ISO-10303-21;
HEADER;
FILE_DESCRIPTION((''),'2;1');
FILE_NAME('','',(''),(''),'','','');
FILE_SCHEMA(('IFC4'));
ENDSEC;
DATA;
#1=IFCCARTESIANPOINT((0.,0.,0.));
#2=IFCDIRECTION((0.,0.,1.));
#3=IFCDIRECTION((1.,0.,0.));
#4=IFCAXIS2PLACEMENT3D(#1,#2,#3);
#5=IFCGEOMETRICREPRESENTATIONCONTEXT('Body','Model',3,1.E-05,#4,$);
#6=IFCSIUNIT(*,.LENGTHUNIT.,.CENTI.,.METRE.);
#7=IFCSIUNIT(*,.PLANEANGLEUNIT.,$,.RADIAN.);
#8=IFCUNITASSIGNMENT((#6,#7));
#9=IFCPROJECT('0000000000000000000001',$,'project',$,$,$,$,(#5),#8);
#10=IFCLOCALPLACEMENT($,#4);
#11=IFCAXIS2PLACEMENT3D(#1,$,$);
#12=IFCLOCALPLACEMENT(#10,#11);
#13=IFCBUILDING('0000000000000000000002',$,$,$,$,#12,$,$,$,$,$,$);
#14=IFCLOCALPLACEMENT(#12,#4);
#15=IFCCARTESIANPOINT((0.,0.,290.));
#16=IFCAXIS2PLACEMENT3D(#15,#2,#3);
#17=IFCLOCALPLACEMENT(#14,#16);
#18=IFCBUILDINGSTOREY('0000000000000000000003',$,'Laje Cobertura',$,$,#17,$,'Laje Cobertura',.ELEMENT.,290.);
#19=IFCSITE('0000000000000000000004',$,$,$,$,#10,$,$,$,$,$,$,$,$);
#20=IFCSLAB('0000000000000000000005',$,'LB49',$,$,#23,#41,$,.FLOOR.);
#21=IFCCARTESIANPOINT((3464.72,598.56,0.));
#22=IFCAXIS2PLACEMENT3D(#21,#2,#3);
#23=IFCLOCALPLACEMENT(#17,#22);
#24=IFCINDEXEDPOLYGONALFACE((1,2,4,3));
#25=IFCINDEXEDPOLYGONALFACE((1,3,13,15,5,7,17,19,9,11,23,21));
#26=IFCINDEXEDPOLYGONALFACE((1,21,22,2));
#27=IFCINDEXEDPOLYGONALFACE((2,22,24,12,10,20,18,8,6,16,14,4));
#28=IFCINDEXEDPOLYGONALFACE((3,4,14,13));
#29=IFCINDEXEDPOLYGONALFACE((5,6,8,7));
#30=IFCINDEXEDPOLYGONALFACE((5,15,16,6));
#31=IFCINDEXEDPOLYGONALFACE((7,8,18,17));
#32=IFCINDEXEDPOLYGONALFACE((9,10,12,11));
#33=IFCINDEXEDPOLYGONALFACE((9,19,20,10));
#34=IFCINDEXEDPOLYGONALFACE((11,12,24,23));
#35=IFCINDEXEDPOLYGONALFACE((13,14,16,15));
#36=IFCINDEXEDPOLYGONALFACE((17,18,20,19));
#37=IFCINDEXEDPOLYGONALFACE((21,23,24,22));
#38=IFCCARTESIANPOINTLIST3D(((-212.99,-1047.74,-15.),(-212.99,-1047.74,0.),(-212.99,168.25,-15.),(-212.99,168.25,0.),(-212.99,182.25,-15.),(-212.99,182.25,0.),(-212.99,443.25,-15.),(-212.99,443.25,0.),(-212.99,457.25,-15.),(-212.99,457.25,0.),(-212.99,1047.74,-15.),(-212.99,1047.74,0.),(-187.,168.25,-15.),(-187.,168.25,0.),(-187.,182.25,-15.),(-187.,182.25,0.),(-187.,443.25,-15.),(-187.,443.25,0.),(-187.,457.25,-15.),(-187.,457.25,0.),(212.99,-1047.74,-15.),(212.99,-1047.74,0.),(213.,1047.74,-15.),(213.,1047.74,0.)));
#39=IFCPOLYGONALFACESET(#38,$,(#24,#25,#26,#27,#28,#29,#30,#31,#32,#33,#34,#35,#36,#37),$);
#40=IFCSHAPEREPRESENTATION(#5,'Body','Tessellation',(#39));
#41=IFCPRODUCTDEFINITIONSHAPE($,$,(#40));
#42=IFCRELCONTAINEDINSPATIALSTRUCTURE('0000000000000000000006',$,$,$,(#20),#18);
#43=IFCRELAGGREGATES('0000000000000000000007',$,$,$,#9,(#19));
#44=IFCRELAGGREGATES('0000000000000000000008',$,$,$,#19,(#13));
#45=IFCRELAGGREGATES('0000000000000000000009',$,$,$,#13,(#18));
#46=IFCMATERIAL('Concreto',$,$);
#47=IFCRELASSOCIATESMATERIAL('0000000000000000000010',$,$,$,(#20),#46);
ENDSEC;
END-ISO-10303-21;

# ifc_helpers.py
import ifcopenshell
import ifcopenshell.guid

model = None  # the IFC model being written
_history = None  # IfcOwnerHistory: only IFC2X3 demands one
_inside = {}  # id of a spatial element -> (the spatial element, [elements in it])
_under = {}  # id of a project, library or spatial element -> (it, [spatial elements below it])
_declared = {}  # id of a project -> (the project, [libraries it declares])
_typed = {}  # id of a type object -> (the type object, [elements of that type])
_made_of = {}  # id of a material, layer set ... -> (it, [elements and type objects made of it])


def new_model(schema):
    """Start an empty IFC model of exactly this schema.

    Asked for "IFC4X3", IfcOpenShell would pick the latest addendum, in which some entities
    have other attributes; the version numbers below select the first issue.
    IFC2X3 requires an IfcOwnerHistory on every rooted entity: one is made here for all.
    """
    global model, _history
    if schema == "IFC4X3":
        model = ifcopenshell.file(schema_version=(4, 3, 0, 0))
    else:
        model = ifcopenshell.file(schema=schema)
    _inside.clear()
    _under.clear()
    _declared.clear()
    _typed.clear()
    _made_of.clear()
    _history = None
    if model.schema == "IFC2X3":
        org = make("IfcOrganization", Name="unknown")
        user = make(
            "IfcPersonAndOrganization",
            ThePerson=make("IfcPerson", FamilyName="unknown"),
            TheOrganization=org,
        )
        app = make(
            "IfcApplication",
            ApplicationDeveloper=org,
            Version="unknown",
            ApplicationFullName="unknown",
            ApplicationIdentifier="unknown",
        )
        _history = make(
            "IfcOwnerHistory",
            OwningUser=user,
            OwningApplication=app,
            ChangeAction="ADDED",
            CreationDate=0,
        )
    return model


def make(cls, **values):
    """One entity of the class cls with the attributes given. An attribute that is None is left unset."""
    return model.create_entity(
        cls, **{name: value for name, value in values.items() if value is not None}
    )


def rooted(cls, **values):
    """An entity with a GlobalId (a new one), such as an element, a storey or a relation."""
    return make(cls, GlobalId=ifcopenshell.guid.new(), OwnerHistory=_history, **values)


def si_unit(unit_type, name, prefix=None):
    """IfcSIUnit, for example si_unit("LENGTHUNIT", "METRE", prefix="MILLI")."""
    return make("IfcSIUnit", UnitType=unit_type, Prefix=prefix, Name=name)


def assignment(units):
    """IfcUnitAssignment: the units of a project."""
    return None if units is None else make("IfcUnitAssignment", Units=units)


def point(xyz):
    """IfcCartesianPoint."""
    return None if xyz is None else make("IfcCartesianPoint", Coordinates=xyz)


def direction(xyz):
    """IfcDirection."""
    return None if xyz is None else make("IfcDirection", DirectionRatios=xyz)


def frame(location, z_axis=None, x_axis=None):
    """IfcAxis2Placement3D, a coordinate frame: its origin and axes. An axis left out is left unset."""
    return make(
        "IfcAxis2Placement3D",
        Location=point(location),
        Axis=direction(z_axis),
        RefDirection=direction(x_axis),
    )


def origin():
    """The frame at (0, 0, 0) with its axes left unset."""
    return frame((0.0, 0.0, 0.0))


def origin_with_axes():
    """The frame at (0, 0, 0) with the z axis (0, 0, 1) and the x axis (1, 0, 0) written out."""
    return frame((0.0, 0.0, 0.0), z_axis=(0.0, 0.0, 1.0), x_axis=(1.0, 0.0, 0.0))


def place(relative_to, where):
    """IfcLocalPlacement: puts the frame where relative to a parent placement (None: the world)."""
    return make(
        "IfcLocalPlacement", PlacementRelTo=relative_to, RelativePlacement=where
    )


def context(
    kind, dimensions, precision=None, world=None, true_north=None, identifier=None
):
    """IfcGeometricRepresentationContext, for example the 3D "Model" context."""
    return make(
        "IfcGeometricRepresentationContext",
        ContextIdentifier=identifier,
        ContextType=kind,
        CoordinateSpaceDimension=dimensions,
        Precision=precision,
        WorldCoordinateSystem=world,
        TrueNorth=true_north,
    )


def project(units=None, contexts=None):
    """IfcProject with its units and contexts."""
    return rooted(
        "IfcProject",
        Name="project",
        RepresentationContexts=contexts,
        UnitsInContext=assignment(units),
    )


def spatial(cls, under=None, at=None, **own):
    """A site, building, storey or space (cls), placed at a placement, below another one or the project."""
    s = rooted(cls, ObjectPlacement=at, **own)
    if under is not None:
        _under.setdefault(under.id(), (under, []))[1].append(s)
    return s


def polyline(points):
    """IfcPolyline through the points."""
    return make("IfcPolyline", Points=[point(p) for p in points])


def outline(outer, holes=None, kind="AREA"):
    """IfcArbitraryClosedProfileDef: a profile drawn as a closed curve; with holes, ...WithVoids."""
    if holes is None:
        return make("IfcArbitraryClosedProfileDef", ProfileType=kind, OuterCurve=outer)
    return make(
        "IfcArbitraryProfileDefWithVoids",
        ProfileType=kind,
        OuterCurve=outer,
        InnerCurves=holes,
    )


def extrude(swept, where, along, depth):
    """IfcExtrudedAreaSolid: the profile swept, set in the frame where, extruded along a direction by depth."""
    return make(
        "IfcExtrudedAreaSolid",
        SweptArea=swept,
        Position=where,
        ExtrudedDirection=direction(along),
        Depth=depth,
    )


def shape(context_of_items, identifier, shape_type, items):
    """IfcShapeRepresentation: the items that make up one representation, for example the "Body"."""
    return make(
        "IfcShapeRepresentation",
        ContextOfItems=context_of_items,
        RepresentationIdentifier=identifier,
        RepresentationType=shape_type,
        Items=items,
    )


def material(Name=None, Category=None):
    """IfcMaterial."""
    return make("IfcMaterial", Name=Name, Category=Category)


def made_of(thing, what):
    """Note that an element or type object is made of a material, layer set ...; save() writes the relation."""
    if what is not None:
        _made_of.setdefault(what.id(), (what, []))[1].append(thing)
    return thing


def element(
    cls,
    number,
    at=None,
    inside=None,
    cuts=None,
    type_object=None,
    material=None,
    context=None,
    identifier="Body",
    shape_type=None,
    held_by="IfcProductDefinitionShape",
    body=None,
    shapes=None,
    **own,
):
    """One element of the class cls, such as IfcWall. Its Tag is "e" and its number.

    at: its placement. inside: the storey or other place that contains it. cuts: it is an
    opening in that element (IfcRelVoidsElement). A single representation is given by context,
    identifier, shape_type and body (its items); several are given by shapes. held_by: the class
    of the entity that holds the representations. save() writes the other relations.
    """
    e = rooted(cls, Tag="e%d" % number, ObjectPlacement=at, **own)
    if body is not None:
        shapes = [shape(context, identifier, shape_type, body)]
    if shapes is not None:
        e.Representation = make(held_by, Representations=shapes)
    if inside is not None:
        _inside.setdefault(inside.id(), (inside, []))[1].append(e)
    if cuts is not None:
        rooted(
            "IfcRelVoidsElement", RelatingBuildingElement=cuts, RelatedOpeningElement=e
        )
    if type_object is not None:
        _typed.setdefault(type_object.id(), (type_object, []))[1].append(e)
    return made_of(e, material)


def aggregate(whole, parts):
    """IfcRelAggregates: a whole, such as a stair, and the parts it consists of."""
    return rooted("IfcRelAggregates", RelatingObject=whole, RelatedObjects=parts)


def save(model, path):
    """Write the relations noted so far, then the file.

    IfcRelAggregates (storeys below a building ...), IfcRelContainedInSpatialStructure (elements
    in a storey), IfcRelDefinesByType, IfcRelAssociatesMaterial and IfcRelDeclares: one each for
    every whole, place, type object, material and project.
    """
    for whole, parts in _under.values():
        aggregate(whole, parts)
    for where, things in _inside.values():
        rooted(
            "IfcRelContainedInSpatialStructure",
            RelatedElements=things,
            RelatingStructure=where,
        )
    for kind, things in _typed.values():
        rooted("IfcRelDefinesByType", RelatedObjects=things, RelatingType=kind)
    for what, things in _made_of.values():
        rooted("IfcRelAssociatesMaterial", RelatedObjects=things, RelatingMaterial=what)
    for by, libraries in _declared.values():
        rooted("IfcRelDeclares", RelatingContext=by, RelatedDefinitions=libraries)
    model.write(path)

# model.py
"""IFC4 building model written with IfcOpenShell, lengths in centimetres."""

from ifc_helpers import new_model, si_unit, frame, origin, origin_with_axes, place, context, project, spatial, polyline, outline, extrude, material, element, save


model = new_model("IFC4")

# Units and contexts
model_context = context("Model", 3, precision=1e-05, world=origin_with_axes(), identifier="Body")
ifc_project = project(units=[si_unit("LENGTHUNIT", "METRE", prefix="CENTI"), si_unit("PLANEANGLEUNIT", "RADIAN")], contexts=[model_context])

# Site, building, storey
site_placement = place(None, origin_with_axes())
site = spatial("IfcSite", under=ifc_project, at=site_placement)
building_placement = place(site_placement, origin())
building = spatial("IfcBuilding", under=site, at=building_placement)
placement = place(building_placement, origin_with_axes())
storey_placement = place(placement, frame((0.0, 0.0, 290.0), z_axis=(0.0, 0.0, 1.0), x_axis=(1.0, 0.0, 0.0)))
storey = spatial("IfcBuildingStorey", under=building, at=storey_placement, Name="Laje Cobertura", LongName="Laje Cobertura", CompositionType="ELEMENT", Elevation=290.0)

# Shared definitions
ifc_material = material(Name="Concreto")

# Slab
slab_1_placement = place(storey_placement, frame((3464.72, 598.56, 0.0), z_axis=(0.0, 0.0, 1.0), x_axis=(1.0, 0.0, 0.0)))
element("IfcSlab", 1, at=slab_1_placement, inside=storey, material=ifc_material, Name="LB49", PredefinedType="FLOOR", context=model_context, shape_type="SolidModel", body=[
    extrude(outline(polyline([(212.99, -1047.74), (213.0, 1047.74), (-213.0, 1047.74), (-213.0, 457.25), (-187.0, 457.25), (-187.0, 443.25), (-213.0, 443.25), (-212.99, 182.25), (-187.0, 182.25), (-187.0, 168.25), (-213.0, 168.25), (-212.99, -1047.74), (212.99, -1047.74), (212.99, -1047.74)])), frame((0.0, 0.0, -15.0), z_axis=(0.0, 0.0, 1.0), x_axis=(1.0, 0.0, 0.0)), (0.0, 0.0, 1.0), 15.0),
])

save(model, "model.ifc")
